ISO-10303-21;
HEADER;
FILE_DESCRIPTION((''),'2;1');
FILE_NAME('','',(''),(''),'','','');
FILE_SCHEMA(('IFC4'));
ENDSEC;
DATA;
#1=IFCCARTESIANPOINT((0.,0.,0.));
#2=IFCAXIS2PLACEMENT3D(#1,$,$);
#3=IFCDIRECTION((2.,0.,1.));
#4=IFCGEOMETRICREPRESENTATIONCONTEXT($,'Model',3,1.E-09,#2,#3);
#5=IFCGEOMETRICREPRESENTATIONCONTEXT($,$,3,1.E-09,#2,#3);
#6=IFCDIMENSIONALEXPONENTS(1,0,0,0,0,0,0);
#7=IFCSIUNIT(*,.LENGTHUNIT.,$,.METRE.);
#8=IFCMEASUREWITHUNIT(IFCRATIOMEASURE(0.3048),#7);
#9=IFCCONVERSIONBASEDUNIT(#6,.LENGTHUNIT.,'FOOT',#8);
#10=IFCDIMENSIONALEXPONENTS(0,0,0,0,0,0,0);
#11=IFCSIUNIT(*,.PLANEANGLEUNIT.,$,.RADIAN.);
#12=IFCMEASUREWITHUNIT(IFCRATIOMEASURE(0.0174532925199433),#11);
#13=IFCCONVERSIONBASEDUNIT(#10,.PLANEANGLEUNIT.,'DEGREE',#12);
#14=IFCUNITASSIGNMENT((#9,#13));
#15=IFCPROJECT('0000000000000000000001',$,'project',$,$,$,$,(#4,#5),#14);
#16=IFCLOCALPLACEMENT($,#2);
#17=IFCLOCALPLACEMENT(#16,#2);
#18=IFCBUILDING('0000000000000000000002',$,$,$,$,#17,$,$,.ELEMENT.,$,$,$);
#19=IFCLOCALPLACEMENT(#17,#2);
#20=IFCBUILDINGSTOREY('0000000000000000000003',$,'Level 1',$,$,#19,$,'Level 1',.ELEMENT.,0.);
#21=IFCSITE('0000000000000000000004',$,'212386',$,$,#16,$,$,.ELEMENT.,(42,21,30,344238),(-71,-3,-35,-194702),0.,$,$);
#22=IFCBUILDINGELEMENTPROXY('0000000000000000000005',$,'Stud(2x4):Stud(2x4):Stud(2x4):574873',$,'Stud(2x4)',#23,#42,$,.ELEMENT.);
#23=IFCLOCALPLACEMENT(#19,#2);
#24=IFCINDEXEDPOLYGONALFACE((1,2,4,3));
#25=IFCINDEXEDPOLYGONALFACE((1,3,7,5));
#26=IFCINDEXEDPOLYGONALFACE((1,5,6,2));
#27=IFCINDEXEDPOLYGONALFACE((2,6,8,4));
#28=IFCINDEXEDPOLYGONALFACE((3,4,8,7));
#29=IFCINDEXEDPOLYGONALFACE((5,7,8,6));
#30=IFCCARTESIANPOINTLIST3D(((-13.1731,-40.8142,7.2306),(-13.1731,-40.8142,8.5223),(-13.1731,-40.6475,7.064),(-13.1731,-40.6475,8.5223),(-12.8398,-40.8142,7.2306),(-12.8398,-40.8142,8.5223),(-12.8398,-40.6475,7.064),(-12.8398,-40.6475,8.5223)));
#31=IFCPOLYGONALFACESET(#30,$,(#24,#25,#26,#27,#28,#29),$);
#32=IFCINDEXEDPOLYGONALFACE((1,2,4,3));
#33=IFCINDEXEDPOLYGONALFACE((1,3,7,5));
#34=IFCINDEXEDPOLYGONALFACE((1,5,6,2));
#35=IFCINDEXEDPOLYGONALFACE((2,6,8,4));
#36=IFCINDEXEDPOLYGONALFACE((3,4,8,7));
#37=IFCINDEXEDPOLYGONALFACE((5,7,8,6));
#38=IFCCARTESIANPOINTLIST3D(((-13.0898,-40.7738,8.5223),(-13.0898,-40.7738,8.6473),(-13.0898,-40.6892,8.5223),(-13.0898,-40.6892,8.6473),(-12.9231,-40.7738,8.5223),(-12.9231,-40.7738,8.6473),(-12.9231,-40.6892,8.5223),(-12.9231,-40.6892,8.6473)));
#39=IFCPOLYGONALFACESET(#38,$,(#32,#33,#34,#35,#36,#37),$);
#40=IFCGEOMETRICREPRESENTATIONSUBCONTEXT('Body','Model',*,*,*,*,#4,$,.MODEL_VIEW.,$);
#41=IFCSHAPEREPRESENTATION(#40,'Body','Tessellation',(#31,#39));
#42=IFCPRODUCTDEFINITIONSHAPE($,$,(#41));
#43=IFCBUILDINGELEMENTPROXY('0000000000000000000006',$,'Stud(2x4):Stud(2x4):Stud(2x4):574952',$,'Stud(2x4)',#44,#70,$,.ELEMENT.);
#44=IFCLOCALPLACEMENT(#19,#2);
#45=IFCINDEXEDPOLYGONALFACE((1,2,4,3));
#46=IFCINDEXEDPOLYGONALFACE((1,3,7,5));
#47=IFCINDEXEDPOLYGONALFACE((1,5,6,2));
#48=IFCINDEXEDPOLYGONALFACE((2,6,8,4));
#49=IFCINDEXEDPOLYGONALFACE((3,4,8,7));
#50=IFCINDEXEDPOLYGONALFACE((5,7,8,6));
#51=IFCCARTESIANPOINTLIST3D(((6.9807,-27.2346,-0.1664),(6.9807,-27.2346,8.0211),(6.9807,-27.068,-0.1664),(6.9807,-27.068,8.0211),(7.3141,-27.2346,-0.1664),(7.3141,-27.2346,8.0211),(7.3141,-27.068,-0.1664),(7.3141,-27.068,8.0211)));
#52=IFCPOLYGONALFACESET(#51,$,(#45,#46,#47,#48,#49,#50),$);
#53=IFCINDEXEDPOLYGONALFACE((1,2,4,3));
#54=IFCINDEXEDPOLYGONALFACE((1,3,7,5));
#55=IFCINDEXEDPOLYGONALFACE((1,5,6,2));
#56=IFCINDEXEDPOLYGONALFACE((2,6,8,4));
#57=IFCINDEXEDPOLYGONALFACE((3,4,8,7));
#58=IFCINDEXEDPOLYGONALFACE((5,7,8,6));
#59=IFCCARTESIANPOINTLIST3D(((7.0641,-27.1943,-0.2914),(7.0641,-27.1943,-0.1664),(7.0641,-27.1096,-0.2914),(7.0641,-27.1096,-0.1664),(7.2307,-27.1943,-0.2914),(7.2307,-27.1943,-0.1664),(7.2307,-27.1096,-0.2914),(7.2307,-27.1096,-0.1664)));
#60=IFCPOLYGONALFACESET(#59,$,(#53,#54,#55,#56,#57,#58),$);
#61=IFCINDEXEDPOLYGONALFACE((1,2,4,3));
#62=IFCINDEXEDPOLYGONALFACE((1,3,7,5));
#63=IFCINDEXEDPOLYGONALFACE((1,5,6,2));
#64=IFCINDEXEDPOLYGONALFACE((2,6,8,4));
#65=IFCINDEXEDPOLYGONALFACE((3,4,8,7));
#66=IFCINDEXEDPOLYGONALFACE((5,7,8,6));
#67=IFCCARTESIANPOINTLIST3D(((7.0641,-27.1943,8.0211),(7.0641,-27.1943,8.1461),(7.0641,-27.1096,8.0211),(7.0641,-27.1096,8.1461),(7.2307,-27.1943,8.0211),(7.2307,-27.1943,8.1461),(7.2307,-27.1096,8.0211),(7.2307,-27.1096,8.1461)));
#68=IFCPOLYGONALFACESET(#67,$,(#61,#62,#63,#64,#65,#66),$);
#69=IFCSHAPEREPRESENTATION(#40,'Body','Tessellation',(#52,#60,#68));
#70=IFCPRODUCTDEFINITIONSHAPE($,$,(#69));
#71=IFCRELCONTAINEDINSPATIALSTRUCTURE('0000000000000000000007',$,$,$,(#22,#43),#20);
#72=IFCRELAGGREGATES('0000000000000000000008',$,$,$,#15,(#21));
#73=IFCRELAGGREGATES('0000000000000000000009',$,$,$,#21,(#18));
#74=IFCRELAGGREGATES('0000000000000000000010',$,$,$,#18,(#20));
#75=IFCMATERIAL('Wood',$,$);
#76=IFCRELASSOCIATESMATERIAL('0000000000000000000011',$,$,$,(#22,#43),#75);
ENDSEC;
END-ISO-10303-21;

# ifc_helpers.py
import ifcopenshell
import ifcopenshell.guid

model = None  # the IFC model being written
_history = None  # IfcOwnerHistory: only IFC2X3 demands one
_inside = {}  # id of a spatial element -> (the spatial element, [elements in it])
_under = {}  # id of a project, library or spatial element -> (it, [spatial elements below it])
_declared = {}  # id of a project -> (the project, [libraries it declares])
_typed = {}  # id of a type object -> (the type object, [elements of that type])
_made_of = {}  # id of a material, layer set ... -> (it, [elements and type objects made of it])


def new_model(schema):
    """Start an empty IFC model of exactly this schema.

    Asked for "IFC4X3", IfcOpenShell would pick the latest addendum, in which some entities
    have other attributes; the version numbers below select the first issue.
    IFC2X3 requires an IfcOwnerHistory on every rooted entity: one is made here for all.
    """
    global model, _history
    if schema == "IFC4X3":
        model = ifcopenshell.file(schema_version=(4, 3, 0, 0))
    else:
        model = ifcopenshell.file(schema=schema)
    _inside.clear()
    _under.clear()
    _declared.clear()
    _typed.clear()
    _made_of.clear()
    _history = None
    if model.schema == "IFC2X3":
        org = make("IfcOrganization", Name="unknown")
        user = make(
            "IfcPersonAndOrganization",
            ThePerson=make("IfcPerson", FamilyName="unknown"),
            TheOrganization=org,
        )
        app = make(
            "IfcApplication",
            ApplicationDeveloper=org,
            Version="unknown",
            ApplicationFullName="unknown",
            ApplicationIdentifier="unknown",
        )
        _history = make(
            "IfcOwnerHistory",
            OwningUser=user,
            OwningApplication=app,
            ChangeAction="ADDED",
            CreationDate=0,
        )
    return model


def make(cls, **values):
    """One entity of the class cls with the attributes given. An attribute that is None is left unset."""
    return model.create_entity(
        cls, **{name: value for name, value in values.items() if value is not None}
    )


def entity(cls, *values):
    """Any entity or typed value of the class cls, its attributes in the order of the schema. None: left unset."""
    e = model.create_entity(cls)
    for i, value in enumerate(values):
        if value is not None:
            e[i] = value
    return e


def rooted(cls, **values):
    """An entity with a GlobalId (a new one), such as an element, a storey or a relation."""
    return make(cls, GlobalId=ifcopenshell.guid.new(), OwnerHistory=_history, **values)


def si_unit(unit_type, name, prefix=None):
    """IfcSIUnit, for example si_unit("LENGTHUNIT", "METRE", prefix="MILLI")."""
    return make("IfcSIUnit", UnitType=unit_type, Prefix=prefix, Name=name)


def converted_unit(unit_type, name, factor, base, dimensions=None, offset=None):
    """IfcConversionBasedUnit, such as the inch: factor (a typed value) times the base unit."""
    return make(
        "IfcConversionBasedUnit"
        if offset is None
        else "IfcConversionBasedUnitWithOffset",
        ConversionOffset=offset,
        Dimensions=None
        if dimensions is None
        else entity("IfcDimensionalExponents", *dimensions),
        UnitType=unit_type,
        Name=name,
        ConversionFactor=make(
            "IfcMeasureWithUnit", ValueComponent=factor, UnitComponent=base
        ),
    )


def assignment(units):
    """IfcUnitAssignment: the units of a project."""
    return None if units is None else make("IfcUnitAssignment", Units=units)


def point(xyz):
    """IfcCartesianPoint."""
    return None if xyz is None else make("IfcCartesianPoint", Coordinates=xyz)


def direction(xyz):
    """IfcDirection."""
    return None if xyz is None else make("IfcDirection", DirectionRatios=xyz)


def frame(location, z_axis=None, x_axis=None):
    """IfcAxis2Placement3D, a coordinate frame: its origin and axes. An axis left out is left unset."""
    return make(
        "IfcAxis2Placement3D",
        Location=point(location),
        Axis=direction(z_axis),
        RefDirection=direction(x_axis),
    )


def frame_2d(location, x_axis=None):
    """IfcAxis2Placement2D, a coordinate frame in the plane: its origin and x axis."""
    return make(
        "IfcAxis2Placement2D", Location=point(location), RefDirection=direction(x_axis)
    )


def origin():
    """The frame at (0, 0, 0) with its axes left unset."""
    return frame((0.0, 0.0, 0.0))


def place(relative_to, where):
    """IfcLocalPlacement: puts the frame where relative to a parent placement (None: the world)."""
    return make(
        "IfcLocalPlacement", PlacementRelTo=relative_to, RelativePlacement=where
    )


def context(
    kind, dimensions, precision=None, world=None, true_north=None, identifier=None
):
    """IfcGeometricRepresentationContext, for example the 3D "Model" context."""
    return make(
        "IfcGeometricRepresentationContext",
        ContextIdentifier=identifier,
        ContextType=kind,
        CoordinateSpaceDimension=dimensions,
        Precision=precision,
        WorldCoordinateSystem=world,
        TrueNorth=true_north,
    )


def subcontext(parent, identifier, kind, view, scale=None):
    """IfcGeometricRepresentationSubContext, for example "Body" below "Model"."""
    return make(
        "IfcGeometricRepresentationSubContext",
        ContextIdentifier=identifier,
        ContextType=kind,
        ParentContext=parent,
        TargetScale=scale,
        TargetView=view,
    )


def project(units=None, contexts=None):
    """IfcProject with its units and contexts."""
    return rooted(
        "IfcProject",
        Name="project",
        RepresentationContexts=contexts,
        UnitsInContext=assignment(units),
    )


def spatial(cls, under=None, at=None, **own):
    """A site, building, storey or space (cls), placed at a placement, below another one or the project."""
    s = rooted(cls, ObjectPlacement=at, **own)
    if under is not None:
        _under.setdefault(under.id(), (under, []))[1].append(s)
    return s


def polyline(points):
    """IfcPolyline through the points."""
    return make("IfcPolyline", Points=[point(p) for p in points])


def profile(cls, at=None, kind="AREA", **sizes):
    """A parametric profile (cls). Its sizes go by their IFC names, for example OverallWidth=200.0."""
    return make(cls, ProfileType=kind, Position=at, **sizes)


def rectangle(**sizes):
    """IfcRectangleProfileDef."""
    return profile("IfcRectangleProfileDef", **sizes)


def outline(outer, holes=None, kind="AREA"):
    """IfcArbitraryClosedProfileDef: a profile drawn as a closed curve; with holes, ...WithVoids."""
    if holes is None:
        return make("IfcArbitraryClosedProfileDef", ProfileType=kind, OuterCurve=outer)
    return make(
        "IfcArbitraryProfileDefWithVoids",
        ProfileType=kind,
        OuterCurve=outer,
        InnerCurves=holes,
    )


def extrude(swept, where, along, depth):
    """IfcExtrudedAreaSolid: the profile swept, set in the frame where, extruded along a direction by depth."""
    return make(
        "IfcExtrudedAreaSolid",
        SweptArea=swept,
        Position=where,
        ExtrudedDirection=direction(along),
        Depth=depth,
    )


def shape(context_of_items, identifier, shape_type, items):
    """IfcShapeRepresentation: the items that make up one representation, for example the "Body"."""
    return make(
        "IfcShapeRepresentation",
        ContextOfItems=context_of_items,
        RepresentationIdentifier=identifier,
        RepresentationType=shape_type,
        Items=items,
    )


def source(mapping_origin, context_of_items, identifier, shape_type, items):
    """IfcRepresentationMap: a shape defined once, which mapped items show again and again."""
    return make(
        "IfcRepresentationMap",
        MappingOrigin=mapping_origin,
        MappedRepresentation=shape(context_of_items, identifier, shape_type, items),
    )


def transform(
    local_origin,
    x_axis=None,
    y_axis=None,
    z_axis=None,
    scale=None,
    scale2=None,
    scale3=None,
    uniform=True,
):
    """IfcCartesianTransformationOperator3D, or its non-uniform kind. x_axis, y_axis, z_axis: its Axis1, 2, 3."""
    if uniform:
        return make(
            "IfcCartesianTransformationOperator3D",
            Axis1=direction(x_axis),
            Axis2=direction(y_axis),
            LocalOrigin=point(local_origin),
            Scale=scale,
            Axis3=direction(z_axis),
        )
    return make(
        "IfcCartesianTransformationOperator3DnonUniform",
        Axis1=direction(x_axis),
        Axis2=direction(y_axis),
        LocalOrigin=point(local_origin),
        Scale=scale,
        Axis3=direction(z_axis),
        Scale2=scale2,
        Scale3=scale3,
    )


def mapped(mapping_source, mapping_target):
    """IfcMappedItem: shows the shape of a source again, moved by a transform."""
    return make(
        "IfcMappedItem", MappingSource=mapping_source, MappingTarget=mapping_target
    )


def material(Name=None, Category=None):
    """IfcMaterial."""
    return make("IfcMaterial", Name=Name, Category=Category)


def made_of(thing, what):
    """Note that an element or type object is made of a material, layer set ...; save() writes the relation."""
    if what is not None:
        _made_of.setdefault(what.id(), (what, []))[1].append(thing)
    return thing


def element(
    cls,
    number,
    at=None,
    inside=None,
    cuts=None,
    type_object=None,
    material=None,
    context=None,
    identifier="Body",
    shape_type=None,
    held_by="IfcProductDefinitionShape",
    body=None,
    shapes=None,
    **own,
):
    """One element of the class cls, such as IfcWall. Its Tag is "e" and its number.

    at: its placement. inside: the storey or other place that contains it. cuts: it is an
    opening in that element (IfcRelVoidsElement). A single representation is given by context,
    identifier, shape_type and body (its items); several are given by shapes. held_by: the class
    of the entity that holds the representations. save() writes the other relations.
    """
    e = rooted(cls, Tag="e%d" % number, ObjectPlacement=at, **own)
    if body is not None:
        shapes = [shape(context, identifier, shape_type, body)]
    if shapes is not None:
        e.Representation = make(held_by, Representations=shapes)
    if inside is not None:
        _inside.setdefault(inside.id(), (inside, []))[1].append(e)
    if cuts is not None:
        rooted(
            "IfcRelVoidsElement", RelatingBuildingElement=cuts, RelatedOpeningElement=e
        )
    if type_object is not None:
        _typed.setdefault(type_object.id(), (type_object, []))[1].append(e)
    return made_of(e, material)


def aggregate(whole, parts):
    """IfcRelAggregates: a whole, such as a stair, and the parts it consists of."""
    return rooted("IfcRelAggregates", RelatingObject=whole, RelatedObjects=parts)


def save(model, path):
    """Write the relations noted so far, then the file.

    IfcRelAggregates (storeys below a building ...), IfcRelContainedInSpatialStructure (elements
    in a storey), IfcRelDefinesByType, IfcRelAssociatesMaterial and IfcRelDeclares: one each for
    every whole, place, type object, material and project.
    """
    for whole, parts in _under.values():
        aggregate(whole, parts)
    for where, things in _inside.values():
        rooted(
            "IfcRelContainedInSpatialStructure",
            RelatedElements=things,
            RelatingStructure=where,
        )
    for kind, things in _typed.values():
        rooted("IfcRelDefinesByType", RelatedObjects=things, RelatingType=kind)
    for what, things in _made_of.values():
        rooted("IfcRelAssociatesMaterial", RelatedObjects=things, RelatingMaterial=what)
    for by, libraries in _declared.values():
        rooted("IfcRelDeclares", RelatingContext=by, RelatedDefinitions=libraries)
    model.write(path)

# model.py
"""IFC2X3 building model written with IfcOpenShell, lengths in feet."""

from ifc_helpers import new_model, entity, si_unit, converted_unit, direction, frame, frame_2d, origin, place, context, subcontext, project, spatial, polyline, rectangle, outline, extrude, source, transform, mapped, material, element, save


model = new_model("IFC2X3")

# Units and contexts
model_context = context("Model", 3, precision=1e-09, world=origin(), true_north=direction((2.0, 0.0, 1.0)))
context_of_model = context(None, 3, precision=1e-09, world=origin(), true_north=direction((2.0, 0.0, 1.0)))
body_context = subcontext(model_context, "Body", "Model", "MODEL_VIEW")
ifc_project = project(units=[converted_unit("LENGTHUNIT", "FOOT", entity("IfcRatioMeasure", 0.3048), si_unit("LENGTHUNIT", "METRE"), dimensions=[1, 0, 0, 0, 0, 0, 0]), converted_unit("PLANEANGLEUNIT", "DEGREE", entity("IfcRatioMeasure", 0.0174532925199433), si_unit("PLANEANGLEUNIT", "RADIAN"), dimensions=[0, 0, 0, 0, 0, 0, 0])], contexts=[model_context, context_of_model])

# Site, building, storey
site_placement = place(None, origin())
site = spatial("IfcSite", under=ifc_project, at=site_placement, Name="212386", CompositionType="ELEMENT", RefLatitude=(42, 21, 30, 344238), RefLongitude=(-71, -3, -35, -194702), RefElevation=0.0)
building_placement = place(site_placement, origin())
building = spatial("IfcBuilding", under=site, at=building_placement, CompositionType="ELEMENT")
storey_placement = place(building_placement, origin())
storey = spatial("IfcBuildingStorey", under=building, at=storey_placement, Name="Level 1", LongName="Level 1", CompositionType="ELEMENT", Elevation=0.0)

# Building element proxies
ifc_material = material(Name="Wood")
shared_shape_1 = source(origin(), body_context, "Body", "SweptSolid", [
    extrude(outline(polyline([(-0.6875, -0.0833), (0.6042, -0.0833), (0.7708, 0.0833), (-0.6875, 0.0833), (-0.6875, -0.0833)])), frame((-13.1731, -40.7308, 7.8348), z_axis=(1.0, 0.0, 0.0), x_axis=(0.0, 0.0, -1.0)), (0.0, 0.0, 1.0), 0.3333),
    extrude(rectangle(XDim=0.1667, YDim=0.0847, at=frame_2d((0.0, 0.0), x_axis=(1.0, 0.0))), frame((-13.0064, -40.7315, 8.5223), z_axis=(0.0, 0.0, 1.0), x_axis=(-1.0, 0.0, 0.0)), (0.0, 0.0, 1.0), 0.125),
])
proxy_1_placement = place(storey_placement, origin())
element("IfcBuildingElementProxy", 1, at=proxy_1_placement, inside=storey, material=ifc_material, Name="Stud(2x4):Stud(2x4):Stud(2x4):574873", ObjectType="Stud(2x4)", CompositionType="ELEMENT", context=body_context, shape_type="MappedRepresentation", body=[
    mapped(shared_shape_1, transform((0.0, 0.0, 0.0), scale=1.0)),
])
shared_shape_2 = source(origin(), body_context, "Body", "SweptSolid", [
    extrude(rectangle(XDim=0.3333, YDim=0.1667, at=frame_2d((0.0, 0.0), x_axis=(1.0, 0.0))), frame((7.1474, -27.1513, -0.1664), z_axis=(0.0, 0.0, 1.0), x_axis=(-1.0, 0.0, 0.0)), (0.0, 0.0, 1.0), 8.1875),
    extrude(rectangle(XDim=0.1667, YDim=0.0847, at=frame_2d((0.0, 0.0), x_axis=(1.0, 0.0))), frame((7.1474, -27.152, -0.2914), z_axis=(0.0, 0.0, 1.0), x_axis=(-1.0, 0.0, 0.0)), (0.0, 0.0, 1.0), 0.125),
    extrude(rectangle(XDim=0.0847, YDim=0.1667, at=frame_2d((0.0, 0.0), x_axis=(1.0, 0.0))), frame((7.1474, -27.152, 8.0211), z_axis=(0.0, 0.0, 1.0), x_axis=(0.0, -1.0, 0.0)), (0.0, 0.0, 1.0), 0.125),
])
proxy_2_placement = place(storey_placement, origin())
element("IfcBuildingElementProxy", 2, at=proxy_2_placement, inside=storey, material=ifc_material, Name="Stud(2x4):Stud(2x4):Stud(2x4):574952", ObjectType="Stud(2x4)", CompositionType="ELEMENT", context=body_context, shape_type="MappedRepresentation", body=[
    mapped(shared_shape_2, transform((0.0, 0.0, 0.0), scale=1.0)),
])

save(model, "model.ifc")
